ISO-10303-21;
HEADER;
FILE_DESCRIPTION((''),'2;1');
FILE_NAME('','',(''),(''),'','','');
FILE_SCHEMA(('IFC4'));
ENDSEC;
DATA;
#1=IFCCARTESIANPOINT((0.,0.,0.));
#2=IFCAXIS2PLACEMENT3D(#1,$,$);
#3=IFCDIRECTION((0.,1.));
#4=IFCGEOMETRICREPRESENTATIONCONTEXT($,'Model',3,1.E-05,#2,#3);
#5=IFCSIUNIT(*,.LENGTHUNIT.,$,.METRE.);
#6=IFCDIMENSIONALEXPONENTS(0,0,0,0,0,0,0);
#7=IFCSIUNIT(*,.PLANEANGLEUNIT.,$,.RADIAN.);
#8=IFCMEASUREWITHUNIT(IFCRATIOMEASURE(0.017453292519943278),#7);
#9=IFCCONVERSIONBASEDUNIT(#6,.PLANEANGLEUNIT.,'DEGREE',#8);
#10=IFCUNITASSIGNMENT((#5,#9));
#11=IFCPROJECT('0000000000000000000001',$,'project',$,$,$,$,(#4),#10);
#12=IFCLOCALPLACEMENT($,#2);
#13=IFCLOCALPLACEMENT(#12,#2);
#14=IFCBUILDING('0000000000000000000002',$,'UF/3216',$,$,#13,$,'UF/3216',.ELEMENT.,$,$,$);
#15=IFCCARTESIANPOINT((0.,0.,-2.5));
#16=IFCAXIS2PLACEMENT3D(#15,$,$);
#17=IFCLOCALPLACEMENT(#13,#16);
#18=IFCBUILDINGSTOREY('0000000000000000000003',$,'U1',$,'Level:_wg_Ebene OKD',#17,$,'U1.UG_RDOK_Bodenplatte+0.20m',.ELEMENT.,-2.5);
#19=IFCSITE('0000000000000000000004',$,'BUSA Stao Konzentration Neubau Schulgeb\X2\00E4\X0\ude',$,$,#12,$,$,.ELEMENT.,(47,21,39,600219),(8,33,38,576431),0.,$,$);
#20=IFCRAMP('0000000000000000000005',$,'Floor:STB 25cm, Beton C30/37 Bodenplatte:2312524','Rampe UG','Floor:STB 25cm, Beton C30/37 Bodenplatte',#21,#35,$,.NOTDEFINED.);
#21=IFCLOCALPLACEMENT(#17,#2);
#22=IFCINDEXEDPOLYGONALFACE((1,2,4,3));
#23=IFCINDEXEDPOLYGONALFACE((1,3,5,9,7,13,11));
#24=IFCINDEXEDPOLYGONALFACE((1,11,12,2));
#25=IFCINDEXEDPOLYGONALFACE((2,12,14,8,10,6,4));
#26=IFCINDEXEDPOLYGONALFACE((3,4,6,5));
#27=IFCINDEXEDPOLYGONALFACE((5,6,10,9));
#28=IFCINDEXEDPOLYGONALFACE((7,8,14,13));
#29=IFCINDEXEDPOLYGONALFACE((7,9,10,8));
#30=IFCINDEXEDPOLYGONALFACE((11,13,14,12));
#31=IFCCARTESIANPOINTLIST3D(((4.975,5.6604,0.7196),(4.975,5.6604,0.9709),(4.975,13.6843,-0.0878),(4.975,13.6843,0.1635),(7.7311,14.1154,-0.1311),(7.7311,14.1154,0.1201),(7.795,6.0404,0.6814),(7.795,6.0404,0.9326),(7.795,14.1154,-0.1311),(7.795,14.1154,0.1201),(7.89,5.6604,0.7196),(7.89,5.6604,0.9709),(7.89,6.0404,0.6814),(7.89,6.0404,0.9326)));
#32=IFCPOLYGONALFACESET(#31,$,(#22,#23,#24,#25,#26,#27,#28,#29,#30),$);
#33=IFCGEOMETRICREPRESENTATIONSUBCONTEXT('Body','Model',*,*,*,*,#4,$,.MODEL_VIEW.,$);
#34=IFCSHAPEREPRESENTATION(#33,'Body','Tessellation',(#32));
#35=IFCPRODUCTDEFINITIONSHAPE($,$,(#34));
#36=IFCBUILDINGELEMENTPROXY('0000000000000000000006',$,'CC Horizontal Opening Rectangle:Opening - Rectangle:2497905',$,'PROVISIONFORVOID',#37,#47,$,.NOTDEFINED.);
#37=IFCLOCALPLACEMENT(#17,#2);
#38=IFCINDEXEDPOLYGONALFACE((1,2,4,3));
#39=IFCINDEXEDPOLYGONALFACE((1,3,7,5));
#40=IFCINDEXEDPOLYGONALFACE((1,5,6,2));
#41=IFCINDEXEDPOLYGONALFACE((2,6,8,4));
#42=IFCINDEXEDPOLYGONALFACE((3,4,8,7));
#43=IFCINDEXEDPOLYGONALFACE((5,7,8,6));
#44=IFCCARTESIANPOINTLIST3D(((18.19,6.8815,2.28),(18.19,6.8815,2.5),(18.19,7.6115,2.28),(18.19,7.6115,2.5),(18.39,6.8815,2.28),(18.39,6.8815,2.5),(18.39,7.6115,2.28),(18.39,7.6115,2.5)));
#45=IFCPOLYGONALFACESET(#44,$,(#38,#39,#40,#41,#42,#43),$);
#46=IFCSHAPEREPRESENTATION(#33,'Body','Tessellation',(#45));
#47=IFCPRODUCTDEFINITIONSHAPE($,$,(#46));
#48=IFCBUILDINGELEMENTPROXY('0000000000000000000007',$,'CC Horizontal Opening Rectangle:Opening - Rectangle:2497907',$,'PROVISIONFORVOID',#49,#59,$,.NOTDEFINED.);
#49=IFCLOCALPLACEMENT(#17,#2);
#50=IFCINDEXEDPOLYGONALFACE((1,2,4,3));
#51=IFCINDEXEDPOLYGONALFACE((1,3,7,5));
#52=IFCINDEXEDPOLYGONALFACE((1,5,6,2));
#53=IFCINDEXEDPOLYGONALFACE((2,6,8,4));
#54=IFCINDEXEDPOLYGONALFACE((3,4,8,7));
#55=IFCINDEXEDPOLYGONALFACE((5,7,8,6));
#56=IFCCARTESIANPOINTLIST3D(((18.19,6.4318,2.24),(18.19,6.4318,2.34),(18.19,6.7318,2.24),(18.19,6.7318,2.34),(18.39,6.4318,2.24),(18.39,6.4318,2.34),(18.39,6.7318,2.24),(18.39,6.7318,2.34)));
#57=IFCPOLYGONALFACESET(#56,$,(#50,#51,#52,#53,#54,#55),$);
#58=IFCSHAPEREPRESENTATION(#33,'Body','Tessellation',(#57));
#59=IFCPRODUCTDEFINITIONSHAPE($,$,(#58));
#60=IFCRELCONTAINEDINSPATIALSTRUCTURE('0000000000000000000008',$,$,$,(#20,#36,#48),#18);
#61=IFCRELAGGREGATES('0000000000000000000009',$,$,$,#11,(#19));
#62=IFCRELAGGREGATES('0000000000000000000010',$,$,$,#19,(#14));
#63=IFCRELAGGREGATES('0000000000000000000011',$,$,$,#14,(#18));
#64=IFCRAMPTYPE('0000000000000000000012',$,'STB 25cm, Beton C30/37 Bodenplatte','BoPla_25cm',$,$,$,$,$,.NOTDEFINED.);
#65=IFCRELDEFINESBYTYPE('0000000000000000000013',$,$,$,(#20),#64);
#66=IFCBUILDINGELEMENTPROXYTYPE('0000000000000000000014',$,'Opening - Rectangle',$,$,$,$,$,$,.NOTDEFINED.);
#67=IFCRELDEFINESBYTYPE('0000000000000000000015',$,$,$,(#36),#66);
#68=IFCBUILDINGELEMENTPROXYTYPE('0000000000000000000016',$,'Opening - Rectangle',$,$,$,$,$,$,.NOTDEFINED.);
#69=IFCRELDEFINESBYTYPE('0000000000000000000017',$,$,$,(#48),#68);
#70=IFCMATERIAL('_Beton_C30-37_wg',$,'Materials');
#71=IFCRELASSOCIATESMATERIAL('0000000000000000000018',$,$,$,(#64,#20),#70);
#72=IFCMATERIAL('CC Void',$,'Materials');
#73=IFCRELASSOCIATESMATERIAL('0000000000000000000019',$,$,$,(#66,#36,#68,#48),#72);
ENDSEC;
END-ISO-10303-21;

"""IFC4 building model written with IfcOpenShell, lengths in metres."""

from ifc_helpers import new_model, entity, si_unit, converted_unit, direction, frame, origin, place, context, subcontext, project, spatial, polyline, indexed_curve, outline, extrude, source, transform, mapped, material, type_object, type_shapes, element, save


model = new_model("IFC4")

# Units and contexts
model_context = context("Model", 3, precision=1e-05, world=origin(), true_north=direction((0.0, 1.0)))
body_context = subcontext(model_context, "Body", "Model", "MODEL_VIEW")
ifc_project = project(units=[si_unit("LENGTHUNIT", "METRE"), converted_unit("PLANEANGLEUNIT", "DEGREE", entity("IfcRatioMeasure", 0.017453292519943278), si_unit("PLANEANGLEUNIT", "RADIAN"), dimensions=[0, 0, 0, 0, 0, 0, 0])], contexts=[model_context])

# Site, building, storey
site_placement = place(None, origin())
site = spatial("IfcSite", under=ifc_project, at=site_placement, Name="BUSA Stao Konzentration Neubau Schulgebäude", CompositionType="ELEMENT", RefLatitude=(47, 21, 39, 600219), RefLongitude=(8, 33, 38, 576431), RefElevation=0.0)
building_placement = place(site_placement, origin())
building = spatial("IfcBuilding", under=site, at=building_placement, Name="UF/3216", LongName="UF/3216", CompositionType="ELEMENT")
storey_placement = place(building_placement, frame((0.0, 0.0, -2.5)))
storey = spatial("IfcBuildingStorey", under=building, at=storey_placement, Name="U1", ObjectType="Level:_wg_Ebene OKD", LongName="U1.UG_RDOK_Bodenplatte+0.20m", CompositionType="ELEMENT", Elevation=-2.5)

# Shared definitions
ifc_material_1 = material(Name="_Beton_C30-37_wg", Category="Materials")

# Ramp
ramp_type = type_object("IfcRampType", Name="STB 25cm, Beton C30/37 Bodenplatte", Description="BoPla_25cm", PredefinedType="NOTDEFINED", material=ifc_material_1)
ramp_placement = place(storey_placement, frame((4.975, 5.6604, -0.1311)))
element("IfcRamp", 1, at=ramp_placement, inside=storey, type_object=ramp_type, material=ifc_material_1, Name="Floor:STB 25cm, Beton C30/37 Bodenplatte:2312524", Description="Rampe UG", ObjectType="Floor:STB 25cm, Beton C30/37 Bodenplatte", PredefinedType="NOTDEFINED", context=body_context, shape_type="SweptSolid", body=[
    extrude(outline(polyline([(1.382, 8.4977), (1.3181, 8.4977), (-1.438, 8.0645), (-1.438, 0.0), (1.477, 0.0), (1.477, 0.3819), (1.382, 0.3819), (1.382, 8.4977)])), frame((1.438, 0.0, 1.102), z_axis=(0.0, 0.100115, 0.994976), x_axis=(1.0, 0.0, 0.0)), (0.0, 0.100115, -0.994976), 0.2513),
])

# Building element proxies
ifc_material_2 = material(Name="CC Void", Category="Materials")
building_element_proxy_type_1 = type_object("IfcBuildingElementProxyType", Name="Opening - Rectangle", PredefinedType="NOTDEFINED", material=ifc_material_2)
shared_shape_1 = source(origin(), body_context, "Body", "SweptSolid", [
    extrude(outline(indexed_curve([(-0.1, -0.365), (0.1, -0.365), (0.1, 0.365), (-0.1, 0.365), (-0.1, -0.365)], self_intersect=False)), frame((0.0, 0.0, -0.22), z_axis=(0.0, 0.0, 1.0), x_axis=(0.0, -1.0, 0.0)), (0.0, 0.0, 1.0), 0.22),
])
type_shapes(building_element_proxy_type_1, [shared_shape_1])
proxy_1_placement = place(storey_placement, frame((18.29, 7.2465, 2.5), z_axis=(0.0, 0.0, 1.0), x_axis=(0.0, 1.0, 0.0)))
element("IfcBuildingElementProxy", 2, at=proxy_1_placement, inside=storey, type_object=building_element_proxy_type_1, material=ifc_material_2, Name="CC Horizontal Opening Rectangle:Opening - Rectangle:2497905", ObjectType="PROVISIONFORVOID", PredefinedType="NOTDEFINED", context=body_context, shape_type="MappedRepresentation", body=[
    mapped(shared_shape_1, transform((0.0, 0.0, 0.0), scale=1.0)),
])
building_element_proxy_type_2 = type_object("IfcBuildingElementProxyType", Name="Opening - Rectangle", PredefinedType="NOTDEFINED", material=ifc_material_2)
shared_shape_2 = source(origin(), body_context, "Body", "SweptSolid", [
    extrude(outline(indexed_curve([(-0.1, -0.15), (0.1, -0.15), (0.1, 0.15), (-0.1, 0.15), (-0.1, -0.15)], self_intersect=False)), frame((0.0, 0.0, -0.26), z_axis=(0.0, 0.0, 1.0), x_axis=(0.0, -1.0, 0.0)), (0.0, 0.0, 1.0), 0.1),
])
type_shapes(building_element_proxy_type_2, [shared_shape_2])
proxy_2_placement = place(storey_placement, frame((18.29, 6.5818, 2.5), z_axis=(0.0, 0.0, 1.0), x_axis=(0.0, 1.0, 0.0)))
element("IfcBuildingElementProxy", 3, at=proxy_2_placement, inside=storey, type_object=building_element_proxy_type_2, material=ifc_material_2, Name="CC Horizontal Opening Rectangle:Opening - Rectangle:2497907", ObjectType="PROVISIONFORVOID", PredefinedType="NOTDEFINED", context=body_context, shape_type="MappedRepresentation", body=[
    mapped(shared_shape_2, transform((0.0, 0.0, 0.0), scale=1.0)),
])

save(model, "model.ifc")
